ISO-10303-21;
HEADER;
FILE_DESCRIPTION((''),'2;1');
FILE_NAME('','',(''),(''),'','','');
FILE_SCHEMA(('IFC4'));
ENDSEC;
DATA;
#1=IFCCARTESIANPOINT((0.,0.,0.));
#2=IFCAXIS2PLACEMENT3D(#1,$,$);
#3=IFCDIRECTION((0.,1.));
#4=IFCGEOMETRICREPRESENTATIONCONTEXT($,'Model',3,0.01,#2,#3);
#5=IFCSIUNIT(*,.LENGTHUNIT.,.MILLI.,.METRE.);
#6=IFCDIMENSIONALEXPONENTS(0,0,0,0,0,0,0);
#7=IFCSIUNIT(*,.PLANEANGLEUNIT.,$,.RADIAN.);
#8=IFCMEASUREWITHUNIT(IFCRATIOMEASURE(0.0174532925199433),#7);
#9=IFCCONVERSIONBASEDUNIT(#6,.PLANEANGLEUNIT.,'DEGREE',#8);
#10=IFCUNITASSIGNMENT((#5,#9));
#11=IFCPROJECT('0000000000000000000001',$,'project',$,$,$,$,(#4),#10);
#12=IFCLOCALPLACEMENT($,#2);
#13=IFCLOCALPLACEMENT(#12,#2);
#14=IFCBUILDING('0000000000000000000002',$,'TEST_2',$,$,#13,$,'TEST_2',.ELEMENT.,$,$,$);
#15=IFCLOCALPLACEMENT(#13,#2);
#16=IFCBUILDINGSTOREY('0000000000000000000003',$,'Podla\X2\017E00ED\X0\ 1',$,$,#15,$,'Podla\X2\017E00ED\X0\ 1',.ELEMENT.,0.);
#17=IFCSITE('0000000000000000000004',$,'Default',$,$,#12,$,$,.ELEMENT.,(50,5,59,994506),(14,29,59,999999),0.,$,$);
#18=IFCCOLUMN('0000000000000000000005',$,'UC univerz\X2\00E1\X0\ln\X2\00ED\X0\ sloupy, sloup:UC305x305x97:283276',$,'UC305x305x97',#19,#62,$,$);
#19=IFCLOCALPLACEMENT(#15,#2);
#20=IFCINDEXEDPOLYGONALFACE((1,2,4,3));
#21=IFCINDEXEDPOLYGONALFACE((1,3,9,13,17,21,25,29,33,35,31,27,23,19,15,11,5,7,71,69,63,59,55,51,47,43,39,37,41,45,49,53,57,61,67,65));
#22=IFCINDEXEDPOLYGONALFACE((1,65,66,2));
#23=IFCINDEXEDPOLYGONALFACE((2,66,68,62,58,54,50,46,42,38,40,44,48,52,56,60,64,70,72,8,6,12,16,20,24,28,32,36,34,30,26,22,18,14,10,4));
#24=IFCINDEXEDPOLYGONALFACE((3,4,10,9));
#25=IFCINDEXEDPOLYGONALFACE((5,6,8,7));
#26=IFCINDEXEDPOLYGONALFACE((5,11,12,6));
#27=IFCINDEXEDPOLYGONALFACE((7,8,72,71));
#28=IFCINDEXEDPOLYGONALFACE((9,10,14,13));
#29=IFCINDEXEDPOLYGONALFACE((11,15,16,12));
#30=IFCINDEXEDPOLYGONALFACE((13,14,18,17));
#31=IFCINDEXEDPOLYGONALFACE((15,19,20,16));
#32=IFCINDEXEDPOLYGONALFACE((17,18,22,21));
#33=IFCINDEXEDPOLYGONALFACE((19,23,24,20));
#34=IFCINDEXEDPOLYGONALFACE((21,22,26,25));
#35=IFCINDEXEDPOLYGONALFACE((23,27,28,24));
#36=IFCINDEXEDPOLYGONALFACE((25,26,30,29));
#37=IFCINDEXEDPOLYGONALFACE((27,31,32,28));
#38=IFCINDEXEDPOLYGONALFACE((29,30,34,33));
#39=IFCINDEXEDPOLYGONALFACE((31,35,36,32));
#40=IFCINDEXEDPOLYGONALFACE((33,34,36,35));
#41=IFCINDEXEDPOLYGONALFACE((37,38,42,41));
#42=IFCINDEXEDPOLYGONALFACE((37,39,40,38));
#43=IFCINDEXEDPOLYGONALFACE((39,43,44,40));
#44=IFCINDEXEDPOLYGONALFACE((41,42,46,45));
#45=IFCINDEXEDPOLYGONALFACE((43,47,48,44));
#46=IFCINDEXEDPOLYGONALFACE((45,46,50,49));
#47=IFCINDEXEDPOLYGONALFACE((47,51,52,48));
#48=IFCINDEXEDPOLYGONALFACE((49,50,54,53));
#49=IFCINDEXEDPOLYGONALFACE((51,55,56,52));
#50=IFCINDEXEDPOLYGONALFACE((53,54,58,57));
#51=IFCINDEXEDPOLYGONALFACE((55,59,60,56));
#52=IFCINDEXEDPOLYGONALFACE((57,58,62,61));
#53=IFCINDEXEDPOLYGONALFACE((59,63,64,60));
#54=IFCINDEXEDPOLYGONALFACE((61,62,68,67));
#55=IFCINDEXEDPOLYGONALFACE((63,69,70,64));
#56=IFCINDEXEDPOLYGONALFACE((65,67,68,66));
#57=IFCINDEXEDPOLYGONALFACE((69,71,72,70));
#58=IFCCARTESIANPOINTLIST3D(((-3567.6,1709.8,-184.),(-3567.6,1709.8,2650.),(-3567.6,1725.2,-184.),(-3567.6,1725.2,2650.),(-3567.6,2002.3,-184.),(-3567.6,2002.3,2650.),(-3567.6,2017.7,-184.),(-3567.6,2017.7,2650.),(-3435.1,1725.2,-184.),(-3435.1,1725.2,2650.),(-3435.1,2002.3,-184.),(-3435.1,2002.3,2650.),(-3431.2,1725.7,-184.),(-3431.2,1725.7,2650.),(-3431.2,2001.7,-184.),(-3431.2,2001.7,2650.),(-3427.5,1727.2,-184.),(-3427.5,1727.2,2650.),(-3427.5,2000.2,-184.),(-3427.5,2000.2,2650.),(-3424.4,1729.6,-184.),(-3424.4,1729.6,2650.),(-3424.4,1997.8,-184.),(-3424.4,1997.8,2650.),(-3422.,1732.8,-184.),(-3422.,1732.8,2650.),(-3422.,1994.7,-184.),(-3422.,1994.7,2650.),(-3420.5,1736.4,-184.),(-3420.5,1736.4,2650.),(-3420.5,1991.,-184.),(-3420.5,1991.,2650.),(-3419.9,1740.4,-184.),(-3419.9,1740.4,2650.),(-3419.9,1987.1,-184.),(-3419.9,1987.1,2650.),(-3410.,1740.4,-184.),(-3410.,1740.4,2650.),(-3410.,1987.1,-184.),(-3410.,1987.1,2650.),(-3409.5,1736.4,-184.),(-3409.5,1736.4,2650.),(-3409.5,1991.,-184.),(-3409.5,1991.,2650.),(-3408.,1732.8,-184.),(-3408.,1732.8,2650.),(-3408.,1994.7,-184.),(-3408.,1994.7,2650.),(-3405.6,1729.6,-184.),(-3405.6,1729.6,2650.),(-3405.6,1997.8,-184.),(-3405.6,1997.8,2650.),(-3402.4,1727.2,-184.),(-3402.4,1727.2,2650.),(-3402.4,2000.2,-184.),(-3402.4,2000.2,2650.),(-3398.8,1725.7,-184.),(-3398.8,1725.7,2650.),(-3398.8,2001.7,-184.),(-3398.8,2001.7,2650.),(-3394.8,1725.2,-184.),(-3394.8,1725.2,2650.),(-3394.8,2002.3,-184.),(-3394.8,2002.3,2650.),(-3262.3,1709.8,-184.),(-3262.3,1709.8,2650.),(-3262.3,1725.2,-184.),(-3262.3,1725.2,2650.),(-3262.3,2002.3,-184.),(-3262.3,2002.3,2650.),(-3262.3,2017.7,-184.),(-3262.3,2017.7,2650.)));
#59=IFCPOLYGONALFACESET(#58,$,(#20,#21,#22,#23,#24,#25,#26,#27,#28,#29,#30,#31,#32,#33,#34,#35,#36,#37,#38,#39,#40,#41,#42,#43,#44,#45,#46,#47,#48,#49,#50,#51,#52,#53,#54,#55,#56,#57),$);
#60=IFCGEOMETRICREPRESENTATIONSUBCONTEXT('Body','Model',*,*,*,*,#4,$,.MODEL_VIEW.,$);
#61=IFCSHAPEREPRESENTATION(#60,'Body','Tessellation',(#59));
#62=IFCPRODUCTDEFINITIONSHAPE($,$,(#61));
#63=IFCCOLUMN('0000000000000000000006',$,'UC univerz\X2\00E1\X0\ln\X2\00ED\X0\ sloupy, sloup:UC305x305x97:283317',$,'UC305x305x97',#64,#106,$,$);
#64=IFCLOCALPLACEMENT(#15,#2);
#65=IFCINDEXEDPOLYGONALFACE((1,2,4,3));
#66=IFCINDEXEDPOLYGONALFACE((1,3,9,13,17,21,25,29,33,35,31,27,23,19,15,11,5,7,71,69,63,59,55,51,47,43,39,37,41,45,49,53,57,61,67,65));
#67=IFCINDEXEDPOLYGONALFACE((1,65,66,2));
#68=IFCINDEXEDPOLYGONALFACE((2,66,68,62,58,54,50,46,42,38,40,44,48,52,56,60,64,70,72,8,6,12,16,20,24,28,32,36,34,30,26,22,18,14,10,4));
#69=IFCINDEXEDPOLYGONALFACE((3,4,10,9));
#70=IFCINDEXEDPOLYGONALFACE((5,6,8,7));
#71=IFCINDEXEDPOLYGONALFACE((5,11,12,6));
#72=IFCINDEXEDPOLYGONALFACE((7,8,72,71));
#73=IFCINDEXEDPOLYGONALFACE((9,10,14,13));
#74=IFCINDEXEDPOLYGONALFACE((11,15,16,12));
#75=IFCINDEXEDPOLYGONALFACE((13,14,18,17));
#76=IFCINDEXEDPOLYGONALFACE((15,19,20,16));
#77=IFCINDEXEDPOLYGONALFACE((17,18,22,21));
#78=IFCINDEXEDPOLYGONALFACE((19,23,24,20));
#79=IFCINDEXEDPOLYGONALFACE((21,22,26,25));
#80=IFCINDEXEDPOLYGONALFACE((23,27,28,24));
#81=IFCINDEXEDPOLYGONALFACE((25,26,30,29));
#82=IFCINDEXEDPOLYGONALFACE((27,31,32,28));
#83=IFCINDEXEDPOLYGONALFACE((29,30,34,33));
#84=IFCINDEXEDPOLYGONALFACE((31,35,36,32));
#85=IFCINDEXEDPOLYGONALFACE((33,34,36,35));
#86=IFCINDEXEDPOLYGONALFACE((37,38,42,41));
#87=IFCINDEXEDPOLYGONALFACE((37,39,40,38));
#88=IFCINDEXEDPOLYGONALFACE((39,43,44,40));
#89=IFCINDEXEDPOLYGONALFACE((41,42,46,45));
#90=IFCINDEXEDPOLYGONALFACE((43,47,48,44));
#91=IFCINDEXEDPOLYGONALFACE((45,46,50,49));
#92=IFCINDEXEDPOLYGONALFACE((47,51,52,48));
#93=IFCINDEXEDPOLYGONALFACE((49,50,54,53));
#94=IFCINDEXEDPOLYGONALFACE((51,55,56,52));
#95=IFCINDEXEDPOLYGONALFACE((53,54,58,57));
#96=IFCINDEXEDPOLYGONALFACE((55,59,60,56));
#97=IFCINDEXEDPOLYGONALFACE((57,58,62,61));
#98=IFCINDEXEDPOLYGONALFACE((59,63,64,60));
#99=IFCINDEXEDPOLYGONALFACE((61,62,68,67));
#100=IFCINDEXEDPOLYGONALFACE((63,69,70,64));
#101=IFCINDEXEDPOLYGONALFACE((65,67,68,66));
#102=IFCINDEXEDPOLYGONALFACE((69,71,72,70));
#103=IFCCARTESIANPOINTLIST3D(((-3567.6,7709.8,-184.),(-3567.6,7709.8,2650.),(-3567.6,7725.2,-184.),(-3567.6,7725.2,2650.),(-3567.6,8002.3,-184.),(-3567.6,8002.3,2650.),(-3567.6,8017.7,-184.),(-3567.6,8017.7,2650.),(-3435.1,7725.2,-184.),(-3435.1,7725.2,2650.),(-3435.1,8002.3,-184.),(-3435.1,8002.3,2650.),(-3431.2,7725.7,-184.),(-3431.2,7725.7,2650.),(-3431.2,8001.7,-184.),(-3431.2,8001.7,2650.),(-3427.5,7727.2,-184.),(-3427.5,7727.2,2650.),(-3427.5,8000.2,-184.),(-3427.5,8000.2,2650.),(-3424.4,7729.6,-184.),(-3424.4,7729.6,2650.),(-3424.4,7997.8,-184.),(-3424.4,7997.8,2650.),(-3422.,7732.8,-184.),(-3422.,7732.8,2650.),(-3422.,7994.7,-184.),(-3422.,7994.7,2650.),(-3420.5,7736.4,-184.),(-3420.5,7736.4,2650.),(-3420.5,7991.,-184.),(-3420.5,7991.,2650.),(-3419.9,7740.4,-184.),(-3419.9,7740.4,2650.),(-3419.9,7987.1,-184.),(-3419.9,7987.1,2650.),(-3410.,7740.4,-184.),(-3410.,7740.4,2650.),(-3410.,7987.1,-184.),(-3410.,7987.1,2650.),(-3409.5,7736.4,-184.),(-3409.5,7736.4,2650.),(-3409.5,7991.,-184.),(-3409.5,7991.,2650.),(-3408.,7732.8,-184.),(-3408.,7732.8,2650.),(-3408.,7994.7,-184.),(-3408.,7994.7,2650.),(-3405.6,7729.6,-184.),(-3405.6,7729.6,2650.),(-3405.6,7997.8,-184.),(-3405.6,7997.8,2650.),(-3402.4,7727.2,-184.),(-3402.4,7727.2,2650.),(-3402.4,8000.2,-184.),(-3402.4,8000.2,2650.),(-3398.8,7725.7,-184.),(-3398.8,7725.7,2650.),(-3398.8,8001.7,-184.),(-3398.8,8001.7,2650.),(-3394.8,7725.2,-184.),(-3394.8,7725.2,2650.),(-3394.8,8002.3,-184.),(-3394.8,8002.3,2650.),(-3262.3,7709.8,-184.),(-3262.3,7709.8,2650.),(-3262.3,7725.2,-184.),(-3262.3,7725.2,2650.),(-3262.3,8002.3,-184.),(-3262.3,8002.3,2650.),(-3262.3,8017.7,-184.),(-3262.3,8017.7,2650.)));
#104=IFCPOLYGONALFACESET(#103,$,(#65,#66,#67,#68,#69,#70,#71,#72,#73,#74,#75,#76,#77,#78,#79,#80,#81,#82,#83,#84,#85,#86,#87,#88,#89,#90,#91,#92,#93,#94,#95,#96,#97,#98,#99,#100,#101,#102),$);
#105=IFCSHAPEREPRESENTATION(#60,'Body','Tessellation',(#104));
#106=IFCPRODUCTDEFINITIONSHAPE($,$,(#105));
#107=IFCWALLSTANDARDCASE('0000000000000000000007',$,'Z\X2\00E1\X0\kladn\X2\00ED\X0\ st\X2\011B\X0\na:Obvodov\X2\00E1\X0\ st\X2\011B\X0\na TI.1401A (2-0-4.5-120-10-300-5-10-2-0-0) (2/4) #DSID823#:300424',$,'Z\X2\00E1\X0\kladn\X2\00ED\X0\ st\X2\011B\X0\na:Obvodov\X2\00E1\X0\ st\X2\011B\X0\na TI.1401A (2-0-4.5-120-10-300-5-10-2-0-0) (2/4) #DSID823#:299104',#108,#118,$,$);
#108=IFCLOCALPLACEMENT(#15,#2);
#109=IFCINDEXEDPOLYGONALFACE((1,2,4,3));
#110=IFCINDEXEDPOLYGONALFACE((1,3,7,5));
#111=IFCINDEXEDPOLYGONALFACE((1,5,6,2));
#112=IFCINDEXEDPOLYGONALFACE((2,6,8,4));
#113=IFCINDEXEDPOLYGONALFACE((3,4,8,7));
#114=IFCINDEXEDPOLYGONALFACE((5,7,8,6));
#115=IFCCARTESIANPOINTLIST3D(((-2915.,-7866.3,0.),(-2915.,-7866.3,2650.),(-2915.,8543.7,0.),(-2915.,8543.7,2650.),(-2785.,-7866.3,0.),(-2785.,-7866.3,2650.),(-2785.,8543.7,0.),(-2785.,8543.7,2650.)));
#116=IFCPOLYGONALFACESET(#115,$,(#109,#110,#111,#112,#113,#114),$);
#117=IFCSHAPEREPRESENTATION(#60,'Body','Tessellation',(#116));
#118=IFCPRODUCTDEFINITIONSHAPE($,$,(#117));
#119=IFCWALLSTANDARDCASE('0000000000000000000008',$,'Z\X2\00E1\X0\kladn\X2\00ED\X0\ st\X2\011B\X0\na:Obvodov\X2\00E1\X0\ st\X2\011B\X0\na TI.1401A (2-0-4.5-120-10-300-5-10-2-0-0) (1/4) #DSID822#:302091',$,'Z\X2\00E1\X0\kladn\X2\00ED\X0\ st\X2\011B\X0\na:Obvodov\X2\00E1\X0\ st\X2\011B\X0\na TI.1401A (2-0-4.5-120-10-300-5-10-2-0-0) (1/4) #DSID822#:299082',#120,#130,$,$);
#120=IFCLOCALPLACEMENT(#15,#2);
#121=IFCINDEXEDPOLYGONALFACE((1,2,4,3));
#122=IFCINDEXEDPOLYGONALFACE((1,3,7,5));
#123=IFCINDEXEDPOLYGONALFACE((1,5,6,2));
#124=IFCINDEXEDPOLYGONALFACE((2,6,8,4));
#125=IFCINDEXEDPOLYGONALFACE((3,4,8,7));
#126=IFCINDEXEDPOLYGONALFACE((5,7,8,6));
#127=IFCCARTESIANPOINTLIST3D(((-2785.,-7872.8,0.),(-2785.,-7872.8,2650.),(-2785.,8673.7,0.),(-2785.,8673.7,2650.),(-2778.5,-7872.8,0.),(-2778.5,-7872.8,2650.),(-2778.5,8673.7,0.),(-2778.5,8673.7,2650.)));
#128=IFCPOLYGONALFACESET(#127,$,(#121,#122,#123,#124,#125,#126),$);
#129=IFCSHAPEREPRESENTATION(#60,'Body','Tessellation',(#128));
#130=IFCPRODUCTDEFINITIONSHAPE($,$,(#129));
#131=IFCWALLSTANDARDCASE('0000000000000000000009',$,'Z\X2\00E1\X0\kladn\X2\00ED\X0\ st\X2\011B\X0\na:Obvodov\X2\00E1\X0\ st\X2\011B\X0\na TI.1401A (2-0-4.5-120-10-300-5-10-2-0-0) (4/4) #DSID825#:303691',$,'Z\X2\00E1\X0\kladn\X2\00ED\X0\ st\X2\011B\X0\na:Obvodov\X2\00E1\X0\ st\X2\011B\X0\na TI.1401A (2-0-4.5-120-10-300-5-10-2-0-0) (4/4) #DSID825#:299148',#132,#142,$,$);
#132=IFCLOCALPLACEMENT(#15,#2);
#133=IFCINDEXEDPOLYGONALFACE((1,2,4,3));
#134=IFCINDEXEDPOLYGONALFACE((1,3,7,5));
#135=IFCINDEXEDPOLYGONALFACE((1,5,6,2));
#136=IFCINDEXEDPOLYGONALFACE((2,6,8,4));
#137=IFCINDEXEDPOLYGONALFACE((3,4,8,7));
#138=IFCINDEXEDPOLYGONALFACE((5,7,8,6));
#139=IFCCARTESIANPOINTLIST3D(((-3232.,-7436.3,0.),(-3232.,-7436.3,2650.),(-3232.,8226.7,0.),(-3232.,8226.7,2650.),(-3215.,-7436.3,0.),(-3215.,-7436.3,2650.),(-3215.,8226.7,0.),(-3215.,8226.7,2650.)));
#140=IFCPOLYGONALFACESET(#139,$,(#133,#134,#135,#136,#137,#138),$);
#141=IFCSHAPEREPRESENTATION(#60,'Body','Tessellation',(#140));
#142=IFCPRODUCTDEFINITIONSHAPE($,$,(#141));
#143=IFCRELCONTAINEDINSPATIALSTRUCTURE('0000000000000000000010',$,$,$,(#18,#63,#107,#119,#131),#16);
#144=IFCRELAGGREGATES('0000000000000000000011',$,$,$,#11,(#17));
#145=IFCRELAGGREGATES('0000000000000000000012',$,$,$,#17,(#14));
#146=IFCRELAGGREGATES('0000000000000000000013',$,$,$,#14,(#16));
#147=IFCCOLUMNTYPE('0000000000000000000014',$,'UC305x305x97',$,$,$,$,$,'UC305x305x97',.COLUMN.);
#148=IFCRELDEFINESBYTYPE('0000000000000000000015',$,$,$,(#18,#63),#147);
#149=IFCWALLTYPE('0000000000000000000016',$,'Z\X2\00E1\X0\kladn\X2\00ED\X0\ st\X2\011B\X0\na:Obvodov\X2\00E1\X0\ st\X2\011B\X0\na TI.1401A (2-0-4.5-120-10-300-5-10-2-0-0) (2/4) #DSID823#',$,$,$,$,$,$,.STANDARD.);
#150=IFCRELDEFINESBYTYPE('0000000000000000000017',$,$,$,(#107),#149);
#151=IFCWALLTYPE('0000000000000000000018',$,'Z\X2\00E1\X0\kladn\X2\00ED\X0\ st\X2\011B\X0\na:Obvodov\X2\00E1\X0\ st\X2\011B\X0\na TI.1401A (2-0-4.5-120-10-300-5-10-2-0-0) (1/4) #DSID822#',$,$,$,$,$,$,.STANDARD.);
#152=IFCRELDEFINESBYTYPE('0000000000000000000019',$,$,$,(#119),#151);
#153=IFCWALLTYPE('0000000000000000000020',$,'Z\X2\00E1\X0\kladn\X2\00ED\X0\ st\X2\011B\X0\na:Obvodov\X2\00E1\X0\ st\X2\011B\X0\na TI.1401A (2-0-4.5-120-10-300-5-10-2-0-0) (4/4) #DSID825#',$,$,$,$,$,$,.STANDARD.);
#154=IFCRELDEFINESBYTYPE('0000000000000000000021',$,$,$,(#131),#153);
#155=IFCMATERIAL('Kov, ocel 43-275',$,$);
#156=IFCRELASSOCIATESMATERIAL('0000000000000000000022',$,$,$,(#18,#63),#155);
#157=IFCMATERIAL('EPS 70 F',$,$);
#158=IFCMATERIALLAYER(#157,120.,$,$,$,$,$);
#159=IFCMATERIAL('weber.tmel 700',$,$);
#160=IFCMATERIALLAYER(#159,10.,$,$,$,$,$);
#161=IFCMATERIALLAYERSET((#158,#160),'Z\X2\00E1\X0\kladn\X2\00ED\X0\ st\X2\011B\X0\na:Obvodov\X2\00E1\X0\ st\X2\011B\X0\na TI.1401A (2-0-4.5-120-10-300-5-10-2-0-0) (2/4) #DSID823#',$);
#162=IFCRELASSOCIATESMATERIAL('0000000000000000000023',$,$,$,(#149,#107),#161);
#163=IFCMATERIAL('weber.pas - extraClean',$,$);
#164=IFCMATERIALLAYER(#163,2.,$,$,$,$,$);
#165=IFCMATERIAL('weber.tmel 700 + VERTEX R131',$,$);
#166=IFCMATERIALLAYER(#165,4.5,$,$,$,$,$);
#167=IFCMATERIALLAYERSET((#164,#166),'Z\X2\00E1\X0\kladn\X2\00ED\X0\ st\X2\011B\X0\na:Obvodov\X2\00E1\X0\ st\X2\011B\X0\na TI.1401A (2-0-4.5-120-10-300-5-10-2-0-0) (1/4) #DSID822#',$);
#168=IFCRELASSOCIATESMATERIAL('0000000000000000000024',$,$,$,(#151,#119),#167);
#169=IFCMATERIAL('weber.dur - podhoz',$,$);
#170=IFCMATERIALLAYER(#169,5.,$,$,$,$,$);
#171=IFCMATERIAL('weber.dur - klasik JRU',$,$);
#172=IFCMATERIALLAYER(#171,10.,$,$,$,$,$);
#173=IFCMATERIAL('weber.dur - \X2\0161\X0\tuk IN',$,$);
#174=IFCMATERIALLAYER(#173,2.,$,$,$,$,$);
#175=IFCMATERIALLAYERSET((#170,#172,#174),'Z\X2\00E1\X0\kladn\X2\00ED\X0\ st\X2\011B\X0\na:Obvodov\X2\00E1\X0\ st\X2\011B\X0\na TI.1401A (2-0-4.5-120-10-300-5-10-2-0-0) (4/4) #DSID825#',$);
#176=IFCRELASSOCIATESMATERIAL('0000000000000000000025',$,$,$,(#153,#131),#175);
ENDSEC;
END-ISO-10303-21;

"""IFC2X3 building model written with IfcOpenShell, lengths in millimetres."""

from ifc_helpers import new_model, entity, si_unit, converted_unit, direction, frame, frame_2d, origin, origin_2d_with_axis, place, context, subcontext, project, spatial, rectangle, i_section, extrude, source, transform, mapped, material, layer, layer_set, layer_usage, type_object, type_shapes, element, save


model = new_model("IFC2X3")

# Units and contexts
model_context = context("Model", 3, precision=0.01, world=origin(), true_north=direction((0.0, 1.0)))
body_context = subcontext(model_context, "Body", "Model", "MODEL_VIEW")
ifc_project = project(units=[si_unit("LENGTHUNIT", "METRE", prefix="MILLI"), converted_unit("PLANEANGLEUNIT", "DEGREE", entity("IfcRatioMeasure", 0.0174532925199433), si_unit("PLANEANGLEUNIT", "RADIAN"), dimensions=[0, 0, 0, 0, 0, 0, 0])], contexts=[model_context])

# Site, building, storey
site_placement = place(None, origin())
site = spatial("IfcSite", under=ifc_project, at=site_placement, Name="Default", CompositionType="ELEMENT", RefLatitude=(50, 5, 59, 994506), RefLongitude=(14, 29, 59, 999999), RefElevation=0.0)
building_placement = place(site_placement, origin())
building = spatial("IfcBuilding", under=site, at=building_placement, Name="TEST_2", LongName="TEST_2", CompositionType="ELEMENT")
storey_placement = place(building_placement, origin())
storey = spatial("IfcBuildingStorey", under=building, at=storey_placement, Name="Podlaží 1", LongName="Podlaží 1", CompositionType="ELEMENT", Elevation=0.0)

# Columns
ifc_material_1 = material(Name="Kov, ocel 43-275")
column_type = type_object("IfcColumnType", Name="UC305x305x97", ElementType="UC305x305x97", PredefinedType="COLUMN")
shared_shape_1 = source(origin(), body_context, "Body", "SweptSolid", [
    extrude(i_section(OverallWidth=305.3, OverallDepth=307.9, WebThickness=9.9, FlangeThickness=15.4, FilletRadius=15.2, at=origin_2d_with_axis()), frame((0.0, 0.0, -184.0), z_axis=(0.0, 0.0, 1.0), x_axis=(-1.0, 0.0, 0.0)), (0.0, 0.0, 1.0), 2834.0),
])
type_shapes(column_type, [shared_shape_1])
for number, where, name in (
    (1, (-3415.0, 1863.7, 0.0), "UC univerzální sloupy, sloup:UC305x305x97:283276"),
    (2, (-3415.0, 7863.7, 0.0), "UC univerzální sloupy, sloup:UC305x305x97:283317"),
):
    element("IfcColumn", number, at=place(storey_placement, frame(where)), inside=storey, type_object=column_type, material=ifc_material_1, Name=name, ObjectType="UC305x305x97", context=body_context, shape_type="MappedRepresentation", body=[
        mapped(shared_shape_1, transform((0.0, 0.0, 0.0), scale=1.0)),
    ])

# Walls
ifc_material_2 = material(Name="EPS 70 F")
ifc_layer_1 = layer(ifc_material_2, 120.0)
ifc_material_3 = material(Name="weber.tmel 700")
ifc_layer_2 = layer(ifc_material_3, 10.0)
ifc_layer_set_1 = layer_set([ifc_layer_1, ifc_layer_2], Name="Základní stěna:Obvodová stěna TI.1401A (2-0-4.5-120-10-300-5-10-2-0-0) (2/4) #DSID823#")
ifc_layer_usage_1 = layer_usage(ifc_layer_set_1, "AXIS2", "NEGATIVE", 65.0)
wall_type_1 = type_object("IfcWallType", Name="Základní stěna:Obvodová stěna TI.1401A (2-0-4.5-120-10-300-5-10-2-0-0) (2/4) #DSID823#", PredefinedType="STANDARD", material=ifc_layer_set_1)
wall_1_placement = place(storey_placement, frame((-2850.0, 8543.7, 0.0), z_axis=(0.0, 0.0, 1.0), x_axis=(0.0, -1.0, 0.0)))
element("IfcWallStandardCase", 3, at=wall_1_placement, inside=storey, type_object=wall_type_1, material=ifc_layer_usage_1, Name="Základní stěna:Obvodová stěna TI.1401A (2-0-4.5-120-10-300-5-10-2-0-0) (2/4) #DSID823#:300424", ObjectType="Základní stěna:Obvodová stěna TI.1401A (2-0-4.5-120-10-300-5-10-2-0-0) (2/4) #DSID823#:299104", context=body_context, shape_type="SweptSolid", body=[
    extrude(rectangle(XDim=16410.0, YDim=130.0, at=frame_2d((8205.0, 0.0), x_axis=(-1.0, 0.0))), origin(), (0.0, 0.0, 1.0), 2650.0),
])
ifc_material_4 = material(Name="weber.pas - extraClean")
ifc_layer_3 = layer(ifc_material_4, 2.0)
ifc_material_5 = material(Name="weber.tmel 700 + VERTEX R131")
ifc_layer_4 = layer(ifc_material_5, 4.5)
ifc_layer_set_2 = layer_set([ifc_layer_3, ifc_layer_4], Name="Základní stěna:Obvodová stěna TI.1401A (2-0-4.5-120-10-300-5-10-2-0-0) (1/4) #DSID822#")
ifc_layer_usage_2 = layer_usage(ifc_layer_set_2, "AXIS2", "NEGATIVE", 3.2)
wall_type_2 = type_object("IfcWallType", Name="Základní stěna:Obvodová stěna TI.1401A (2-0-4.5-120-10-300-5-10-2-0-0) (1/4) #DSID822#", PredefinedType="STANDARD", material=ifc_layer_set_2)
wall_2_placement = place(storey_placement, frame((-2781.7, 8673.7, 0.0), z_axis=(0.0, 0.0, 1.0), x_axis=(0.0, -1.0, 0.0)))
element("IfcWallStandardCase", 4, at=wall_2_placement, inside=storey, type_object=wall_type_2, material=ifc_layer_usage_2, Name="Základní stěna:Obvodová stěna TI.1401A (2-0-4.5-120-10-300-5-10-2-0-0) (1/4) #DSID822#:302091", ObjectType="Základní stěna:Obvodová stěna TI.1401A (2-0-4.5-120-10-300-5-10-2-0-0) (1/4) #DSID822#:299082", context=body_context, shape_type="SweptSolid", body=[
    extrude(rectangle(XDim=16546.5, YDim=6.5, at=frame_2d((8273.2, 0.0), x_axis=(-1.0, 0.0))), origin(), (0.0, 0.0, 1.0), 2650.0),
])
ifc_material_6 = material(Name="weber.dur - podhoz")
ifc_layer_5 = layer(ifc_material_6, 5.0)
ifc_material_7 = material(Name="weber.dur - klasik JRU")
ifc_layer_6 = layer(ifc_material_7, 10.0)
ifc_material_8 = material(Name="weber.dur - štuk IN")
ifc_layer_7 = layer(ifc_material_8, 2.0)
ifc_layer_set_3 = layer_set([ifc_layer_5, ifc_layer_6, ifc_layer_7], Name="Základní stěna:Obvodová stěna TI.1401A (2-0-4.5-120-10-300-5-10-2-0-0) (4/4) #DSID825#")
ifc_layer_usage_3 = layer_usage(ifc_layer_set_3, "AXIS2", "POSITIVE", -8.5)
wall_type_3 = type_object("IfcWallType", Name="Základní stěna:Obvodová stěna TI.1401A (2-0-4.5-120-10-300-5-10-2-0-0) (4/4) #DSID825#", PredefinedType="STANDARD", material=ifc_layer_set_3)
wall_3_placement = place(storey_placement, frame((-3223.5, 8226.7, 0.0), z_axis=(0.0, 0.0, 1.0), x_axis=(0.0, -1.0, 0.0)))
element("IfcWallStandardCase", 5, at=wall_3_placement, inside=storey, type_object=wall_type_3, material=ifc_layer_usage_3, Name="Základní stěna:Obvodová stěna TI.1401A (2-0-4.5-120-10-300-5-10-2-0-0) (4/4) #DSID825#:303691", ObjectType="Základní stěna:Obvodová stěna TI.1401A (2-0-4.5-120-10-300-5-10-2-0-0) (4/4) #DSID825#:299148", context=body_context, shape_type="SweptSolid", body=[
    extrude(rectangle(XDim=15663.0, YDim=17.0, at=frame_2d((7831.5, 0.0), x_axis=(-1.0, 0.0))), origin(), (0.0, 0.0, 1.0), 2650.0),
])

save(model, "model.ifc")
